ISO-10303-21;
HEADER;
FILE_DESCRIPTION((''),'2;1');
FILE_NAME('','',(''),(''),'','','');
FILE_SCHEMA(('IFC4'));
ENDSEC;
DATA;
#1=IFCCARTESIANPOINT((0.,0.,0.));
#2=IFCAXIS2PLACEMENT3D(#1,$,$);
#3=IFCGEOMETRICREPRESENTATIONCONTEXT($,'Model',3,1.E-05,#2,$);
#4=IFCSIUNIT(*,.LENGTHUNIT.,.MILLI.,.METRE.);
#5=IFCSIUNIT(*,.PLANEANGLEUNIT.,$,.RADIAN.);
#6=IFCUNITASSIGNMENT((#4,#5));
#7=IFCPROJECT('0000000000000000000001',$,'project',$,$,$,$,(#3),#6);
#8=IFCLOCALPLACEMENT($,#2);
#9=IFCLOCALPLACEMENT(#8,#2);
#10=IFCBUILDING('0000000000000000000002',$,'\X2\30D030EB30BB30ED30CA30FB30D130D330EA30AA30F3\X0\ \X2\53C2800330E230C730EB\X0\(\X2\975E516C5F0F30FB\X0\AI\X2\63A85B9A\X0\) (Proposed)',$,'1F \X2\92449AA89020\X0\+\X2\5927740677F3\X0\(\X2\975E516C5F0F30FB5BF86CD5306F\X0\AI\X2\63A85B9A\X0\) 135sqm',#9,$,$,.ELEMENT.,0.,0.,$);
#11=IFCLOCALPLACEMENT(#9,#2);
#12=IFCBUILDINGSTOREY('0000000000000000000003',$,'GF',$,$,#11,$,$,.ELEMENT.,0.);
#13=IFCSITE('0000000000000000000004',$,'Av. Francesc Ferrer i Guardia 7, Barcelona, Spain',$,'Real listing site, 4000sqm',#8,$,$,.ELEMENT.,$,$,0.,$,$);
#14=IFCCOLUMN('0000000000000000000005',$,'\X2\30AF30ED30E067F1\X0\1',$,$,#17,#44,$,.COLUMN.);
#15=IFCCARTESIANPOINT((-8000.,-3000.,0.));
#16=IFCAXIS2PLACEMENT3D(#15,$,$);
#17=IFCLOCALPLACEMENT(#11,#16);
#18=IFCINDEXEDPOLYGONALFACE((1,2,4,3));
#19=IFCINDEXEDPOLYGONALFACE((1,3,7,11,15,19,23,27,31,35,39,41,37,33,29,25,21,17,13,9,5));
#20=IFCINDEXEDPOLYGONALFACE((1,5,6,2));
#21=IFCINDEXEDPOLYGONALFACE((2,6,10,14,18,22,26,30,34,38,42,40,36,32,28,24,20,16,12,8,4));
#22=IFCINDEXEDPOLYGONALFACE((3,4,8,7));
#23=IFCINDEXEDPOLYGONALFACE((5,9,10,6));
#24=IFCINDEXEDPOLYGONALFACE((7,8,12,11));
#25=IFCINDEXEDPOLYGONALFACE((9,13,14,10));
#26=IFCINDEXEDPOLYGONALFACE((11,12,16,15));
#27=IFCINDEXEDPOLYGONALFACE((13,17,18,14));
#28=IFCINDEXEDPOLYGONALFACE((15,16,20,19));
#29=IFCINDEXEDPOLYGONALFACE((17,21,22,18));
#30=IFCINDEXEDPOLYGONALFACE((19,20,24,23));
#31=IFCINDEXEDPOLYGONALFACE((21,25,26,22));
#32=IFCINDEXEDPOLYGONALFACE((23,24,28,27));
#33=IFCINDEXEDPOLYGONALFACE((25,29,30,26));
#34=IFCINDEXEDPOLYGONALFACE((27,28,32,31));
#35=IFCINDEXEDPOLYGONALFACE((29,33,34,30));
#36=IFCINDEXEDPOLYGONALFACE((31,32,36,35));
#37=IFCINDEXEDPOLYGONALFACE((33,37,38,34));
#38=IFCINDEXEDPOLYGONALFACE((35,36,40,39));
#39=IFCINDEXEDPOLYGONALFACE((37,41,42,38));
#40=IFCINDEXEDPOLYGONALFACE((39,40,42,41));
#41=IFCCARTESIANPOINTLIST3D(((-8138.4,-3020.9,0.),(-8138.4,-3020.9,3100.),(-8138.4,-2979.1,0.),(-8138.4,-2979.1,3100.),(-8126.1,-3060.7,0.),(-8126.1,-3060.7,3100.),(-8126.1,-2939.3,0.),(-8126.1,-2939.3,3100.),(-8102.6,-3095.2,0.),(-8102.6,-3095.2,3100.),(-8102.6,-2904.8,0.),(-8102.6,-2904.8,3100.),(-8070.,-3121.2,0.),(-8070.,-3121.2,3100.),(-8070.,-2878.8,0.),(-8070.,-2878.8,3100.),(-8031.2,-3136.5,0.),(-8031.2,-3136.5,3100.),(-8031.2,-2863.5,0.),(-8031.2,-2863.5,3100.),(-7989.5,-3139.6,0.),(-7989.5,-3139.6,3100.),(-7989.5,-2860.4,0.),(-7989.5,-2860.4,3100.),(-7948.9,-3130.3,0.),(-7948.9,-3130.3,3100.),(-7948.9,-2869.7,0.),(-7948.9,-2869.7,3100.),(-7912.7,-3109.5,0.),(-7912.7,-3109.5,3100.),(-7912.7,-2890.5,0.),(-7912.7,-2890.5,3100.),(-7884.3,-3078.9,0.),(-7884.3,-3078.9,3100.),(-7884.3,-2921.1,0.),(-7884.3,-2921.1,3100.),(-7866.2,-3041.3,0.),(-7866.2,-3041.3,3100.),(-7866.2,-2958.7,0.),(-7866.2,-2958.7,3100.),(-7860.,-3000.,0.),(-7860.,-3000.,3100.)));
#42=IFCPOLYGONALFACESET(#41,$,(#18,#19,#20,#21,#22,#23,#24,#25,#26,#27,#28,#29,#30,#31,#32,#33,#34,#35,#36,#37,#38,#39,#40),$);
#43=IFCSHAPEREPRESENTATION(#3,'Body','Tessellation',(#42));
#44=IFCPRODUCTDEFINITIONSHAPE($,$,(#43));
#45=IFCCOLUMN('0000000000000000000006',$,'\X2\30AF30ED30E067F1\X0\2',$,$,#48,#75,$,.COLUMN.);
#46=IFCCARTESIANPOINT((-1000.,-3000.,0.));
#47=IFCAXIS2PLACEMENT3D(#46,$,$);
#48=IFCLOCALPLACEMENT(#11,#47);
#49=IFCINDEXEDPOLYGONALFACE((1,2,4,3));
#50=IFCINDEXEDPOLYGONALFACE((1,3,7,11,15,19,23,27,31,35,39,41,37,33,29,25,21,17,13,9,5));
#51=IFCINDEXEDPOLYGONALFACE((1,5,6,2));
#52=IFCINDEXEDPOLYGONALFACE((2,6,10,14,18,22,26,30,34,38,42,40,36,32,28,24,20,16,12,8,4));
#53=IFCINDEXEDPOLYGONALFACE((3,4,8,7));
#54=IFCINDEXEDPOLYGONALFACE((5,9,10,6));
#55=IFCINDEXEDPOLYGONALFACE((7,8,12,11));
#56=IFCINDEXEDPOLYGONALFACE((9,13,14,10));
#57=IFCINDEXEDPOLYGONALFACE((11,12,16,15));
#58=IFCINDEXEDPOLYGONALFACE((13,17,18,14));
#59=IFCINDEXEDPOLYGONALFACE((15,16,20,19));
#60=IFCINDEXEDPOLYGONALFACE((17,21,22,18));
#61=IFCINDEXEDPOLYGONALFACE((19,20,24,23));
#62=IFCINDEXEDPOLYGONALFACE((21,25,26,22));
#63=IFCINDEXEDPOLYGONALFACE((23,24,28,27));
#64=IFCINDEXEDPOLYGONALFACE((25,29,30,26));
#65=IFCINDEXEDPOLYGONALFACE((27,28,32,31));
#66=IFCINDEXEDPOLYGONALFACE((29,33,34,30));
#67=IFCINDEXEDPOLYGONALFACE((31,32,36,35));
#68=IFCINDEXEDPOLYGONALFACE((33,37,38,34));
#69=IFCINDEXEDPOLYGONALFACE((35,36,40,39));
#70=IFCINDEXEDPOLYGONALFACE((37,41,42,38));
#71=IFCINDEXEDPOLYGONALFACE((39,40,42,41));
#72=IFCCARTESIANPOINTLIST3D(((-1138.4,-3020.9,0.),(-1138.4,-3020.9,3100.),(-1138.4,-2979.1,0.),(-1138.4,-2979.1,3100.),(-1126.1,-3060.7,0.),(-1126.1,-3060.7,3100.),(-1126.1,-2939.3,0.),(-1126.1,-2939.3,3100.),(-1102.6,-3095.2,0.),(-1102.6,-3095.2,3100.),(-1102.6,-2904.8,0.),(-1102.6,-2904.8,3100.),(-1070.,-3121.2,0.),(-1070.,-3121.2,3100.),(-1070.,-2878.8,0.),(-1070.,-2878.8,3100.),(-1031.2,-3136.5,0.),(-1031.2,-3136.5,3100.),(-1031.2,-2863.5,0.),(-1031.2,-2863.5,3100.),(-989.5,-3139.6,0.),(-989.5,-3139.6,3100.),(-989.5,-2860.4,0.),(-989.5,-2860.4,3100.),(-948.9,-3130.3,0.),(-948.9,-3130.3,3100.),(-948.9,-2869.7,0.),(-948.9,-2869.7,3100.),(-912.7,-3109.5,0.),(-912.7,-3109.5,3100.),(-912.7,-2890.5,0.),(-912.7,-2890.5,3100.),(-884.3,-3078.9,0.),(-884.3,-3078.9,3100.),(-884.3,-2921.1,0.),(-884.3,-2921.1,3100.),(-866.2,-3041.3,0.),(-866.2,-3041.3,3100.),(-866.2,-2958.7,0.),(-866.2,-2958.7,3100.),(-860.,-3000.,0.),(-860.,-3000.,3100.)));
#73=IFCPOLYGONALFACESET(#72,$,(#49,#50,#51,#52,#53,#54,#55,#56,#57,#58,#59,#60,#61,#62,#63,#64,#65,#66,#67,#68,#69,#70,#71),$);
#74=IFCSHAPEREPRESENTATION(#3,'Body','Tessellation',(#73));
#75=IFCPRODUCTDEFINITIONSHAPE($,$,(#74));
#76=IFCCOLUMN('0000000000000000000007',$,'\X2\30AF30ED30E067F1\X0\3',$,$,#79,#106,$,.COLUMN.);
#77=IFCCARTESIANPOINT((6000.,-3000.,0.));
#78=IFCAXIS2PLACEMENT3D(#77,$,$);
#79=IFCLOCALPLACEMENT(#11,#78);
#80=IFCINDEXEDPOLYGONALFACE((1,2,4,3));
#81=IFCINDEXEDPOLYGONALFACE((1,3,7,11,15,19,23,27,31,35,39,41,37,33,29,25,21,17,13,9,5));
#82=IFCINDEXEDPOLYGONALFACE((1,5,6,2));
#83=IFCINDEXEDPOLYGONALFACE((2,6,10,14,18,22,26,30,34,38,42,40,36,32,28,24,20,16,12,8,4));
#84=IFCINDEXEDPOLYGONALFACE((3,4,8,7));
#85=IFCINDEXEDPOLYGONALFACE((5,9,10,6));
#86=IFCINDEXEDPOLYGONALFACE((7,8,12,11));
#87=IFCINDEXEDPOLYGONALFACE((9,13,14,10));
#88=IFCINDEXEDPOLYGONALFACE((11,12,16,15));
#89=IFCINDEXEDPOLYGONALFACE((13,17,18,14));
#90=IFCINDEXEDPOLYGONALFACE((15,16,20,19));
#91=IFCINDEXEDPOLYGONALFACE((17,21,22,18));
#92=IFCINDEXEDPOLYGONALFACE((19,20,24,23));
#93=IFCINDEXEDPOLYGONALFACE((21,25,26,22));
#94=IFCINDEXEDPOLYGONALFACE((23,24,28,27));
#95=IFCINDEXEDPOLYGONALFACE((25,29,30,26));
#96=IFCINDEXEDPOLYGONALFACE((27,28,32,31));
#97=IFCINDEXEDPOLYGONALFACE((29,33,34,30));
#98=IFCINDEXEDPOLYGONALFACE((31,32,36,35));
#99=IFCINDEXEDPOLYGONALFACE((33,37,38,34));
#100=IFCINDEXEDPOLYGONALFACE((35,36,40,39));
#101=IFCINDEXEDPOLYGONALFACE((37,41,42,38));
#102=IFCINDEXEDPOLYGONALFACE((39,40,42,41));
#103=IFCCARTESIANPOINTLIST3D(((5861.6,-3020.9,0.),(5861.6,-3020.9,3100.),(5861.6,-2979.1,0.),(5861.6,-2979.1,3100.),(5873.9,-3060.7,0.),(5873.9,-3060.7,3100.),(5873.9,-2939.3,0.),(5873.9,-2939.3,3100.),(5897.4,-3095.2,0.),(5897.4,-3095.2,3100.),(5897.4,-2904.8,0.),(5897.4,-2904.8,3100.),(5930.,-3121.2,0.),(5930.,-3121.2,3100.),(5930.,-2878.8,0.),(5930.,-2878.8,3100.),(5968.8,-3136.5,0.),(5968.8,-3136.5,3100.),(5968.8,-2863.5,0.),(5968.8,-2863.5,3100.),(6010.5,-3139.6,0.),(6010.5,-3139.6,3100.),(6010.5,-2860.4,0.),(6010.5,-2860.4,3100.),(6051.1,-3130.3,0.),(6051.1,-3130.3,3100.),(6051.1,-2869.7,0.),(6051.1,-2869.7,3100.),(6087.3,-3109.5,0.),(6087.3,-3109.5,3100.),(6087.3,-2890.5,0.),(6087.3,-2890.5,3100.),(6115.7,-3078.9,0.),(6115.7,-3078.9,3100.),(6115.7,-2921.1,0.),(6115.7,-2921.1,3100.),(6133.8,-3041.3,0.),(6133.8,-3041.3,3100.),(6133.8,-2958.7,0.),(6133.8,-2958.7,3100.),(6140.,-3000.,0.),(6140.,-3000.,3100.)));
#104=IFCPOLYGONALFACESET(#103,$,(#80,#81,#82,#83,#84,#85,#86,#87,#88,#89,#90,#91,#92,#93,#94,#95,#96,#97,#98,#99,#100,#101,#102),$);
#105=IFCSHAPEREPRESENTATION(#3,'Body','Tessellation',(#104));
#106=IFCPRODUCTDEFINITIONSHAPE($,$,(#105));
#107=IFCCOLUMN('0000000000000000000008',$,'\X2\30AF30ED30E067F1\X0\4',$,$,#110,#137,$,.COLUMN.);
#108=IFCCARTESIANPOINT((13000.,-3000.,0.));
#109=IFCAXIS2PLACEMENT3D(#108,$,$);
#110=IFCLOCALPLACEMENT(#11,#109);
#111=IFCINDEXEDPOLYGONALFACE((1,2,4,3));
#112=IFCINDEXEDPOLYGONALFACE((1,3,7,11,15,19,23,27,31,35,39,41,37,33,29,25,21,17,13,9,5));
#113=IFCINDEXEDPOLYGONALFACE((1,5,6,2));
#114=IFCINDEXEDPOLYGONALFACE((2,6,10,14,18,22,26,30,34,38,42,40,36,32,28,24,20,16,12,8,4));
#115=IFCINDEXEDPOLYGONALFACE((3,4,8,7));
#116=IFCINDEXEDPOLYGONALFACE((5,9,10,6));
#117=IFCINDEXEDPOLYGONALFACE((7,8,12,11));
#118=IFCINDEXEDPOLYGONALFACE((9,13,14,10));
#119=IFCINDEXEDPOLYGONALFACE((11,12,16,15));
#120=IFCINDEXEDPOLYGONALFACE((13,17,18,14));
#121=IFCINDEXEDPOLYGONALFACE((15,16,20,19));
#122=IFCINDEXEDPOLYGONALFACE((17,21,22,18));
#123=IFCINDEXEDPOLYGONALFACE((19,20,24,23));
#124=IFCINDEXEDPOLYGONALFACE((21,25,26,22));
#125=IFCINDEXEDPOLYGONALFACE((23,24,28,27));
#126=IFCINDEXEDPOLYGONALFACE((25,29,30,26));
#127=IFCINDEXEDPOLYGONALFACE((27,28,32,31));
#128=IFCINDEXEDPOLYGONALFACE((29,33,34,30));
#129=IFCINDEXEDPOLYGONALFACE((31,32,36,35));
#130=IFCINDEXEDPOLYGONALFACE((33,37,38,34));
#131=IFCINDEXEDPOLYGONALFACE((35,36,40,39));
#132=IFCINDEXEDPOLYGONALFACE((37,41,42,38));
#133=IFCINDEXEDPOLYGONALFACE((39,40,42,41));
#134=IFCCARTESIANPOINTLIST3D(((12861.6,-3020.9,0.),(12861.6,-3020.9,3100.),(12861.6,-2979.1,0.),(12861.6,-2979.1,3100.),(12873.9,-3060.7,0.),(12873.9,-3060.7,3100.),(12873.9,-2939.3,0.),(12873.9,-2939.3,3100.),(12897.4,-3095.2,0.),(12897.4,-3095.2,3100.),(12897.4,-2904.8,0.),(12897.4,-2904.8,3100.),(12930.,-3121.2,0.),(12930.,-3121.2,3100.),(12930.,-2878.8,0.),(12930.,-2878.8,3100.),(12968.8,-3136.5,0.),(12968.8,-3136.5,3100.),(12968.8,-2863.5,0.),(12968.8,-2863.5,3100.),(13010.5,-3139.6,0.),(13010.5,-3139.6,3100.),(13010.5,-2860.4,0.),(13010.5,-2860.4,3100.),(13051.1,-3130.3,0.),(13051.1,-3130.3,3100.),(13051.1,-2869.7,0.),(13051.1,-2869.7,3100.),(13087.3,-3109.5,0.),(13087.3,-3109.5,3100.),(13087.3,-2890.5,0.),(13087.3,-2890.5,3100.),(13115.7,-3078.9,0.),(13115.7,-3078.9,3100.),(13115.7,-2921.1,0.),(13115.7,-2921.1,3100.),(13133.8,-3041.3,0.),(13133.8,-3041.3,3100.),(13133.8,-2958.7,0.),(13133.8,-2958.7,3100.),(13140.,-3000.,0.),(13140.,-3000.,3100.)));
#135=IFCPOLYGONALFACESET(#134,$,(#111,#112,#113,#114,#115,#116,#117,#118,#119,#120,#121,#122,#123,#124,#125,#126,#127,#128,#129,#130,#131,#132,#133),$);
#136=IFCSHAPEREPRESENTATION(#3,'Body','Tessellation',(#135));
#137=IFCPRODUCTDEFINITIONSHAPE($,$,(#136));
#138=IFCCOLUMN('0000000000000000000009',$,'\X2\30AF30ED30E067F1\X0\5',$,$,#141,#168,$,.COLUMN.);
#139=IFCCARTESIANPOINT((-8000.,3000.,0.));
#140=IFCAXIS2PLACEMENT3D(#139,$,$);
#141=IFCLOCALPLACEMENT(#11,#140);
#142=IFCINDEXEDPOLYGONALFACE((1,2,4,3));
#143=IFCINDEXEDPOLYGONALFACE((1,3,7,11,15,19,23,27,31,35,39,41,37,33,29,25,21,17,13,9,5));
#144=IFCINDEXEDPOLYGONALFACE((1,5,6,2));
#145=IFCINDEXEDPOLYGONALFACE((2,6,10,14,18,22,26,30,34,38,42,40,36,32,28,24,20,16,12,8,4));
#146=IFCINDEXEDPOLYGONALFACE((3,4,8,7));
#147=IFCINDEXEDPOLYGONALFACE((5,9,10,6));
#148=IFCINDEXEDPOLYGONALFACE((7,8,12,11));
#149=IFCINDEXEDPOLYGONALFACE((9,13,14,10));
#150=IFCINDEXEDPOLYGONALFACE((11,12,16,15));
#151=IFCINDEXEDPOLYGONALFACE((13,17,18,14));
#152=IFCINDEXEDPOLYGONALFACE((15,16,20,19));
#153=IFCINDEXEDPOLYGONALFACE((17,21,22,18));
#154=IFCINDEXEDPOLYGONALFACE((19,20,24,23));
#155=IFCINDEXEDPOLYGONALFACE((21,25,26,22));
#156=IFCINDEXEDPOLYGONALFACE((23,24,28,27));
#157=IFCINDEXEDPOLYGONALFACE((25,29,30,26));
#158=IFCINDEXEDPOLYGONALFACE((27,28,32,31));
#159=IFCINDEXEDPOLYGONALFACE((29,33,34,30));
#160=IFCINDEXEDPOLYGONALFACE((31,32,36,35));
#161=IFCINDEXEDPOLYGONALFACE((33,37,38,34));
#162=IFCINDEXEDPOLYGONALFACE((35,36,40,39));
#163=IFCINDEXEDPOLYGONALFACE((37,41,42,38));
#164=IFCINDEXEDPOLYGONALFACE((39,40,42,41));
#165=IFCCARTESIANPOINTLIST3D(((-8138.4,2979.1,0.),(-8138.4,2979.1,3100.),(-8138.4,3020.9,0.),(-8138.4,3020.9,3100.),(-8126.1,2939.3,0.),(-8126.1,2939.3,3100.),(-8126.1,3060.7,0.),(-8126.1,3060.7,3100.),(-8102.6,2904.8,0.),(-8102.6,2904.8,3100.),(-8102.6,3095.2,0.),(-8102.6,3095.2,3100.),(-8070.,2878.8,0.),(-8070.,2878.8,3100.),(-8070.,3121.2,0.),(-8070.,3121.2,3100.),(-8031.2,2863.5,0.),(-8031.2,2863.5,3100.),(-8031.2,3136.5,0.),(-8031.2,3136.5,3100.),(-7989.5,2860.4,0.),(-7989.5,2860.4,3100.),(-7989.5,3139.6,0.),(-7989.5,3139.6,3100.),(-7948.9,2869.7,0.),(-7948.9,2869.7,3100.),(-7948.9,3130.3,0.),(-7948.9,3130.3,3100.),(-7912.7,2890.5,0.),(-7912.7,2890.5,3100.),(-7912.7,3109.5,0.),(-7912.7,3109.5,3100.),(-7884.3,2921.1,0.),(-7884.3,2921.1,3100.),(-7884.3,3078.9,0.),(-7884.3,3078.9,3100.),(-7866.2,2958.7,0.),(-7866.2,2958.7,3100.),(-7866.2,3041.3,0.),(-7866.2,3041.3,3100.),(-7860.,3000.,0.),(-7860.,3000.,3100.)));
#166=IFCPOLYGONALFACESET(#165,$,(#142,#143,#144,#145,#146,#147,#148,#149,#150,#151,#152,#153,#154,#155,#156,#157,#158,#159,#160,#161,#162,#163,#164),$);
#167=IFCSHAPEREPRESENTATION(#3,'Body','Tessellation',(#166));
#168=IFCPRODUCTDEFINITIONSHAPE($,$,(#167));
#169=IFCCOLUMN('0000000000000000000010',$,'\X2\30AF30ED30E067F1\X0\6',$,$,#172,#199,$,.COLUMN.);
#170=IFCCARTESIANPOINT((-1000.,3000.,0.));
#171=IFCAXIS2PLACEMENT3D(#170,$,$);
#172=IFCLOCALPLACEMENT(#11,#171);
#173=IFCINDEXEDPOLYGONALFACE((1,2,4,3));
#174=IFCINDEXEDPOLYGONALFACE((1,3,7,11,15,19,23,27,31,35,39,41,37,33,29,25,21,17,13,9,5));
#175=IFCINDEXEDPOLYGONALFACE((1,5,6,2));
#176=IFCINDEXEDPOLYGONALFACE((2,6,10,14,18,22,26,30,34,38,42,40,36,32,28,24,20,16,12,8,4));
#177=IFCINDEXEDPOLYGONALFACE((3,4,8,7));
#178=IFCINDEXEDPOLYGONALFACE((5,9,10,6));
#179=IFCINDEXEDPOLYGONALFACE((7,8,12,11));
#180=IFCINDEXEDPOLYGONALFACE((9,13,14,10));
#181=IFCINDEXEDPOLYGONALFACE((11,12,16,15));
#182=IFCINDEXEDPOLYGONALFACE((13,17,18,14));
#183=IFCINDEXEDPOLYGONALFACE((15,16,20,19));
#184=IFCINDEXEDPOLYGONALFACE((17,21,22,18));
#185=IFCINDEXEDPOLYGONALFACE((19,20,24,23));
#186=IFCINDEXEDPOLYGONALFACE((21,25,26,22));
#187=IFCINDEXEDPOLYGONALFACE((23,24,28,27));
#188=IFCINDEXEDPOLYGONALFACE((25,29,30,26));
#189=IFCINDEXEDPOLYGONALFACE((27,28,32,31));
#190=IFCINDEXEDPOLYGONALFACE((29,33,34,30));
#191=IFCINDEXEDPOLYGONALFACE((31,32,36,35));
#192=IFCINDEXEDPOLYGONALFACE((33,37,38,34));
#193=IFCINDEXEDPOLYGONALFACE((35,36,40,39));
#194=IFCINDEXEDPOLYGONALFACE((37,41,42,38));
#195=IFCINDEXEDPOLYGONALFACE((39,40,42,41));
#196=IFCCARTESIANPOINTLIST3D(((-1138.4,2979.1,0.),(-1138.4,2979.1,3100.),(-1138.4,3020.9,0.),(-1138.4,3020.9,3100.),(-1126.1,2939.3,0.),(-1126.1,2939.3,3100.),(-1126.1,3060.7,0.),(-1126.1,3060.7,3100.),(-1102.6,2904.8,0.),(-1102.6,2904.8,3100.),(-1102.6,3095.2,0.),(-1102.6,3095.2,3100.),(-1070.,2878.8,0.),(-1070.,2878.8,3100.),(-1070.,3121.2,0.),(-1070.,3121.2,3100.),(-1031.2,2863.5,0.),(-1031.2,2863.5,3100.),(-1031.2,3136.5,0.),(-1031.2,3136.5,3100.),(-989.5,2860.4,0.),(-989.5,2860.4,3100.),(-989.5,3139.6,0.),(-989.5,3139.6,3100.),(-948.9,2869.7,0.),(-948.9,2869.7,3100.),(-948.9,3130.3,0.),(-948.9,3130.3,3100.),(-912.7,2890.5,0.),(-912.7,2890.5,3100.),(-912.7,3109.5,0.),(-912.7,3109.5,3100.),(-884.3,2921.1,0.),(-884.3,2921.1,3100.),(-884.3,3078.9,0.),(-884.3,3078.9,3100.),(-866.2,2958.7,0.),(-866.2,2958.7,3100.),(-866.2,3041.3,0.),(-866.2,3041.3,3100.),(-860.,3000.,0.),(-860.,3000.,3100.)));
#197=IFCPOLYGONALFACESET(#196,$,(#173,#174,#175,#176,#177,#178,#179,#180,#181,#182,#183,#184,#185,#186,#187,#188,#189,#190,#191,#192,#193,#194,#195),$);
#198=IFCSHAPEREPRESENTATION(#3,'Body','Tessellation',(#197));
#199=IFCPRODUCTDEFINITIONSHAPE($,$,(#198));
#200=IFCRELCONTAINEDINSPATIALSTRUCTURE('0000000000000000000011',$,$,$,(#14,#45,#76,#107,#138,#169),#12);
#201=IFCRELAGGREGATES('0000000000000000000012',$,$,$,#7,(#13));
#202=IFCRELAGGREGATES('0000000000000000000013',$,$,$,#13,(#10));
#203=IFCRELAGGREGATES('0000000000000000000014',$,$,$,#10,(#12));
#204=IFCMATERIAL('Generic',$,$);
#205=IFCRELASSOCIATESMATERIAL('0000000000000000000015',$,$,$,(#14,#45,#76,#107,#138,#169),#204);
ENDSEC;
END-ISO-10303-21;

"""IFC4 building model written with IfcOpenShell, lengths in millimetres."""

from ifc_helpers import new_model, si_unit, frame, origin, origin_2d, place, context, project, spatial, circle, extrude, material, element, save


model = new_model("IFC4")

# Units and contexts
model_context = context("Model", 3, precision=1e-05, world=origin())
ifc_project = project(units=[si_unit("LENGTHUNIT", "METRE", prefix="MILLI"), si_unit("PLANEANGLEUNIT", "RADIAN")], contexts=[model_context])

# Site, building, storey
site_placement = place(None, origin())
site = spatial("IfcSite", under=ifc_project, at=site_placement, Name="Av. Francesc Ferrer i Guardia 7, Barcelona, Spain", ObjectType="Real listing site, 4000sqm", CompositionType="ELEMENT", RefElevation=0.0)
building_placement = place(site_placement, origin())
building = spatial("IfcBuilding", under=site, at=building_placement, Name="バルセロナ・パビリオン 参考モデル(非公式・AI推定) (Proposed)", ObjectType="1F 鉄骨造+大理石(非公式・寸法はAI推定) 135sqm", CompositionType="ELEMENT", ElevationOfRefHeight=0.0, ElevationOfTerrain=0.0)
storey_placement = place(building_placement, origin())
storey = spatial("IfcBuildingStorey", under=building, at=storey_placement, Name="GF", CompositionType="ELEMENT", Elevation=0.0)

# Columns
ifc_material_1 = material(Name="Generic")
column_1_placement = place(storey_placement, frame((-8000.0, -3000.0, 0.0)))
element("IfcColumn", 1, at=column_1_placement, inside=storey, material=ifc_material_1, Name="クロム柱1", PredefinedType="COLUMN", context=model_context, shape_type="SweptSolid", body=[
    extrude(circle(Radius=140.0, at=origin_2d()), frame((-8000.0, -3000.0, 0.0)), (0.0, 0.0, 1.0), 3100.0),
])
column_2_placement = place(storey_placement, frame((-1000.0, -3000.0, 0.0)))
element("IfcColumn", 2, at=column_2_placement, inside=storey, material=ifc_material_1, Name="クロム柱2", PredefinedType="COLUMN", context=model_context, shape_type="SweptSolid", body=[
    extrude(circle(Radius=140.0, at=origin_2d()), frame((-1000.0, -3000.0, 0.0)), (0.0, 0.0, 1.0), 3100.0),
])
column_3_placement = place(storey_placement, frame((6000.0, -3000.0, 0.0)))
element("IfcColumn", 3, at=column_3_placement, inside=storey, material=ifc_material_1, Name="クロム柱3", PredefinedType="COLUMN", context=model_context, shape_type="SweptSolid", body=[
    extrude(circle(Radius=140.0, at=origin_2d()), frame((6000.0, -3000.0, 0.0)), (0.0, 0.0, 1.0), 3100.0),
])
column_4_placement = place(storey_placement, frame((13000.0, -3000.0, 0.0)))
element("IfcColumn", 4, at=column_4_placement, inside=storey, material=ifc_material_1, Name="クロム柱4", PredefinedType="COLUMN", context=model_context, shape_type="SweptSolid", body=[
    extrude(circle(Radius=140.0, at=origin_2d()), frame((13000.0, -3000.0, 0.0)), (0.0, 0.0, 1.0), 3100.0),
])
column_5_placement = place(storey_placement, frame((-8000.0, 3000.0, 0.0)))
element("IfcColumn", 5, at=column_5_placement, inside=storey, material=ifc_material_1, Name="クロム柱5", PredefinedType="COLUMN", context=model_context, shape_type="SweptSolid", body=[
    extrude(circle(Radius=140.0, at=origin_2d()), frame((-8000.0, 3000.0, 0.0)), (0.0, 0.0, 1.0), 3100.0),
])
column_6_placement = place(storey_placement, frame((-1000.0, 3000.0, 0.0)))
element("IfcColumn", 6, at=column_6_placement, inside=storey, material=ifc_material_1, Name="クロム柱6", PredefinedType="COLUMN", context=model_context, shape_type="SweptSolid", body=[
    extrude(circle(Radius=140.0, at=origin_2d()), frame((-1000.0, 3000.0, 0.0)), (0.0, 0.0, 1.0), 3100.0),
])

save(model, "model.ifc")
